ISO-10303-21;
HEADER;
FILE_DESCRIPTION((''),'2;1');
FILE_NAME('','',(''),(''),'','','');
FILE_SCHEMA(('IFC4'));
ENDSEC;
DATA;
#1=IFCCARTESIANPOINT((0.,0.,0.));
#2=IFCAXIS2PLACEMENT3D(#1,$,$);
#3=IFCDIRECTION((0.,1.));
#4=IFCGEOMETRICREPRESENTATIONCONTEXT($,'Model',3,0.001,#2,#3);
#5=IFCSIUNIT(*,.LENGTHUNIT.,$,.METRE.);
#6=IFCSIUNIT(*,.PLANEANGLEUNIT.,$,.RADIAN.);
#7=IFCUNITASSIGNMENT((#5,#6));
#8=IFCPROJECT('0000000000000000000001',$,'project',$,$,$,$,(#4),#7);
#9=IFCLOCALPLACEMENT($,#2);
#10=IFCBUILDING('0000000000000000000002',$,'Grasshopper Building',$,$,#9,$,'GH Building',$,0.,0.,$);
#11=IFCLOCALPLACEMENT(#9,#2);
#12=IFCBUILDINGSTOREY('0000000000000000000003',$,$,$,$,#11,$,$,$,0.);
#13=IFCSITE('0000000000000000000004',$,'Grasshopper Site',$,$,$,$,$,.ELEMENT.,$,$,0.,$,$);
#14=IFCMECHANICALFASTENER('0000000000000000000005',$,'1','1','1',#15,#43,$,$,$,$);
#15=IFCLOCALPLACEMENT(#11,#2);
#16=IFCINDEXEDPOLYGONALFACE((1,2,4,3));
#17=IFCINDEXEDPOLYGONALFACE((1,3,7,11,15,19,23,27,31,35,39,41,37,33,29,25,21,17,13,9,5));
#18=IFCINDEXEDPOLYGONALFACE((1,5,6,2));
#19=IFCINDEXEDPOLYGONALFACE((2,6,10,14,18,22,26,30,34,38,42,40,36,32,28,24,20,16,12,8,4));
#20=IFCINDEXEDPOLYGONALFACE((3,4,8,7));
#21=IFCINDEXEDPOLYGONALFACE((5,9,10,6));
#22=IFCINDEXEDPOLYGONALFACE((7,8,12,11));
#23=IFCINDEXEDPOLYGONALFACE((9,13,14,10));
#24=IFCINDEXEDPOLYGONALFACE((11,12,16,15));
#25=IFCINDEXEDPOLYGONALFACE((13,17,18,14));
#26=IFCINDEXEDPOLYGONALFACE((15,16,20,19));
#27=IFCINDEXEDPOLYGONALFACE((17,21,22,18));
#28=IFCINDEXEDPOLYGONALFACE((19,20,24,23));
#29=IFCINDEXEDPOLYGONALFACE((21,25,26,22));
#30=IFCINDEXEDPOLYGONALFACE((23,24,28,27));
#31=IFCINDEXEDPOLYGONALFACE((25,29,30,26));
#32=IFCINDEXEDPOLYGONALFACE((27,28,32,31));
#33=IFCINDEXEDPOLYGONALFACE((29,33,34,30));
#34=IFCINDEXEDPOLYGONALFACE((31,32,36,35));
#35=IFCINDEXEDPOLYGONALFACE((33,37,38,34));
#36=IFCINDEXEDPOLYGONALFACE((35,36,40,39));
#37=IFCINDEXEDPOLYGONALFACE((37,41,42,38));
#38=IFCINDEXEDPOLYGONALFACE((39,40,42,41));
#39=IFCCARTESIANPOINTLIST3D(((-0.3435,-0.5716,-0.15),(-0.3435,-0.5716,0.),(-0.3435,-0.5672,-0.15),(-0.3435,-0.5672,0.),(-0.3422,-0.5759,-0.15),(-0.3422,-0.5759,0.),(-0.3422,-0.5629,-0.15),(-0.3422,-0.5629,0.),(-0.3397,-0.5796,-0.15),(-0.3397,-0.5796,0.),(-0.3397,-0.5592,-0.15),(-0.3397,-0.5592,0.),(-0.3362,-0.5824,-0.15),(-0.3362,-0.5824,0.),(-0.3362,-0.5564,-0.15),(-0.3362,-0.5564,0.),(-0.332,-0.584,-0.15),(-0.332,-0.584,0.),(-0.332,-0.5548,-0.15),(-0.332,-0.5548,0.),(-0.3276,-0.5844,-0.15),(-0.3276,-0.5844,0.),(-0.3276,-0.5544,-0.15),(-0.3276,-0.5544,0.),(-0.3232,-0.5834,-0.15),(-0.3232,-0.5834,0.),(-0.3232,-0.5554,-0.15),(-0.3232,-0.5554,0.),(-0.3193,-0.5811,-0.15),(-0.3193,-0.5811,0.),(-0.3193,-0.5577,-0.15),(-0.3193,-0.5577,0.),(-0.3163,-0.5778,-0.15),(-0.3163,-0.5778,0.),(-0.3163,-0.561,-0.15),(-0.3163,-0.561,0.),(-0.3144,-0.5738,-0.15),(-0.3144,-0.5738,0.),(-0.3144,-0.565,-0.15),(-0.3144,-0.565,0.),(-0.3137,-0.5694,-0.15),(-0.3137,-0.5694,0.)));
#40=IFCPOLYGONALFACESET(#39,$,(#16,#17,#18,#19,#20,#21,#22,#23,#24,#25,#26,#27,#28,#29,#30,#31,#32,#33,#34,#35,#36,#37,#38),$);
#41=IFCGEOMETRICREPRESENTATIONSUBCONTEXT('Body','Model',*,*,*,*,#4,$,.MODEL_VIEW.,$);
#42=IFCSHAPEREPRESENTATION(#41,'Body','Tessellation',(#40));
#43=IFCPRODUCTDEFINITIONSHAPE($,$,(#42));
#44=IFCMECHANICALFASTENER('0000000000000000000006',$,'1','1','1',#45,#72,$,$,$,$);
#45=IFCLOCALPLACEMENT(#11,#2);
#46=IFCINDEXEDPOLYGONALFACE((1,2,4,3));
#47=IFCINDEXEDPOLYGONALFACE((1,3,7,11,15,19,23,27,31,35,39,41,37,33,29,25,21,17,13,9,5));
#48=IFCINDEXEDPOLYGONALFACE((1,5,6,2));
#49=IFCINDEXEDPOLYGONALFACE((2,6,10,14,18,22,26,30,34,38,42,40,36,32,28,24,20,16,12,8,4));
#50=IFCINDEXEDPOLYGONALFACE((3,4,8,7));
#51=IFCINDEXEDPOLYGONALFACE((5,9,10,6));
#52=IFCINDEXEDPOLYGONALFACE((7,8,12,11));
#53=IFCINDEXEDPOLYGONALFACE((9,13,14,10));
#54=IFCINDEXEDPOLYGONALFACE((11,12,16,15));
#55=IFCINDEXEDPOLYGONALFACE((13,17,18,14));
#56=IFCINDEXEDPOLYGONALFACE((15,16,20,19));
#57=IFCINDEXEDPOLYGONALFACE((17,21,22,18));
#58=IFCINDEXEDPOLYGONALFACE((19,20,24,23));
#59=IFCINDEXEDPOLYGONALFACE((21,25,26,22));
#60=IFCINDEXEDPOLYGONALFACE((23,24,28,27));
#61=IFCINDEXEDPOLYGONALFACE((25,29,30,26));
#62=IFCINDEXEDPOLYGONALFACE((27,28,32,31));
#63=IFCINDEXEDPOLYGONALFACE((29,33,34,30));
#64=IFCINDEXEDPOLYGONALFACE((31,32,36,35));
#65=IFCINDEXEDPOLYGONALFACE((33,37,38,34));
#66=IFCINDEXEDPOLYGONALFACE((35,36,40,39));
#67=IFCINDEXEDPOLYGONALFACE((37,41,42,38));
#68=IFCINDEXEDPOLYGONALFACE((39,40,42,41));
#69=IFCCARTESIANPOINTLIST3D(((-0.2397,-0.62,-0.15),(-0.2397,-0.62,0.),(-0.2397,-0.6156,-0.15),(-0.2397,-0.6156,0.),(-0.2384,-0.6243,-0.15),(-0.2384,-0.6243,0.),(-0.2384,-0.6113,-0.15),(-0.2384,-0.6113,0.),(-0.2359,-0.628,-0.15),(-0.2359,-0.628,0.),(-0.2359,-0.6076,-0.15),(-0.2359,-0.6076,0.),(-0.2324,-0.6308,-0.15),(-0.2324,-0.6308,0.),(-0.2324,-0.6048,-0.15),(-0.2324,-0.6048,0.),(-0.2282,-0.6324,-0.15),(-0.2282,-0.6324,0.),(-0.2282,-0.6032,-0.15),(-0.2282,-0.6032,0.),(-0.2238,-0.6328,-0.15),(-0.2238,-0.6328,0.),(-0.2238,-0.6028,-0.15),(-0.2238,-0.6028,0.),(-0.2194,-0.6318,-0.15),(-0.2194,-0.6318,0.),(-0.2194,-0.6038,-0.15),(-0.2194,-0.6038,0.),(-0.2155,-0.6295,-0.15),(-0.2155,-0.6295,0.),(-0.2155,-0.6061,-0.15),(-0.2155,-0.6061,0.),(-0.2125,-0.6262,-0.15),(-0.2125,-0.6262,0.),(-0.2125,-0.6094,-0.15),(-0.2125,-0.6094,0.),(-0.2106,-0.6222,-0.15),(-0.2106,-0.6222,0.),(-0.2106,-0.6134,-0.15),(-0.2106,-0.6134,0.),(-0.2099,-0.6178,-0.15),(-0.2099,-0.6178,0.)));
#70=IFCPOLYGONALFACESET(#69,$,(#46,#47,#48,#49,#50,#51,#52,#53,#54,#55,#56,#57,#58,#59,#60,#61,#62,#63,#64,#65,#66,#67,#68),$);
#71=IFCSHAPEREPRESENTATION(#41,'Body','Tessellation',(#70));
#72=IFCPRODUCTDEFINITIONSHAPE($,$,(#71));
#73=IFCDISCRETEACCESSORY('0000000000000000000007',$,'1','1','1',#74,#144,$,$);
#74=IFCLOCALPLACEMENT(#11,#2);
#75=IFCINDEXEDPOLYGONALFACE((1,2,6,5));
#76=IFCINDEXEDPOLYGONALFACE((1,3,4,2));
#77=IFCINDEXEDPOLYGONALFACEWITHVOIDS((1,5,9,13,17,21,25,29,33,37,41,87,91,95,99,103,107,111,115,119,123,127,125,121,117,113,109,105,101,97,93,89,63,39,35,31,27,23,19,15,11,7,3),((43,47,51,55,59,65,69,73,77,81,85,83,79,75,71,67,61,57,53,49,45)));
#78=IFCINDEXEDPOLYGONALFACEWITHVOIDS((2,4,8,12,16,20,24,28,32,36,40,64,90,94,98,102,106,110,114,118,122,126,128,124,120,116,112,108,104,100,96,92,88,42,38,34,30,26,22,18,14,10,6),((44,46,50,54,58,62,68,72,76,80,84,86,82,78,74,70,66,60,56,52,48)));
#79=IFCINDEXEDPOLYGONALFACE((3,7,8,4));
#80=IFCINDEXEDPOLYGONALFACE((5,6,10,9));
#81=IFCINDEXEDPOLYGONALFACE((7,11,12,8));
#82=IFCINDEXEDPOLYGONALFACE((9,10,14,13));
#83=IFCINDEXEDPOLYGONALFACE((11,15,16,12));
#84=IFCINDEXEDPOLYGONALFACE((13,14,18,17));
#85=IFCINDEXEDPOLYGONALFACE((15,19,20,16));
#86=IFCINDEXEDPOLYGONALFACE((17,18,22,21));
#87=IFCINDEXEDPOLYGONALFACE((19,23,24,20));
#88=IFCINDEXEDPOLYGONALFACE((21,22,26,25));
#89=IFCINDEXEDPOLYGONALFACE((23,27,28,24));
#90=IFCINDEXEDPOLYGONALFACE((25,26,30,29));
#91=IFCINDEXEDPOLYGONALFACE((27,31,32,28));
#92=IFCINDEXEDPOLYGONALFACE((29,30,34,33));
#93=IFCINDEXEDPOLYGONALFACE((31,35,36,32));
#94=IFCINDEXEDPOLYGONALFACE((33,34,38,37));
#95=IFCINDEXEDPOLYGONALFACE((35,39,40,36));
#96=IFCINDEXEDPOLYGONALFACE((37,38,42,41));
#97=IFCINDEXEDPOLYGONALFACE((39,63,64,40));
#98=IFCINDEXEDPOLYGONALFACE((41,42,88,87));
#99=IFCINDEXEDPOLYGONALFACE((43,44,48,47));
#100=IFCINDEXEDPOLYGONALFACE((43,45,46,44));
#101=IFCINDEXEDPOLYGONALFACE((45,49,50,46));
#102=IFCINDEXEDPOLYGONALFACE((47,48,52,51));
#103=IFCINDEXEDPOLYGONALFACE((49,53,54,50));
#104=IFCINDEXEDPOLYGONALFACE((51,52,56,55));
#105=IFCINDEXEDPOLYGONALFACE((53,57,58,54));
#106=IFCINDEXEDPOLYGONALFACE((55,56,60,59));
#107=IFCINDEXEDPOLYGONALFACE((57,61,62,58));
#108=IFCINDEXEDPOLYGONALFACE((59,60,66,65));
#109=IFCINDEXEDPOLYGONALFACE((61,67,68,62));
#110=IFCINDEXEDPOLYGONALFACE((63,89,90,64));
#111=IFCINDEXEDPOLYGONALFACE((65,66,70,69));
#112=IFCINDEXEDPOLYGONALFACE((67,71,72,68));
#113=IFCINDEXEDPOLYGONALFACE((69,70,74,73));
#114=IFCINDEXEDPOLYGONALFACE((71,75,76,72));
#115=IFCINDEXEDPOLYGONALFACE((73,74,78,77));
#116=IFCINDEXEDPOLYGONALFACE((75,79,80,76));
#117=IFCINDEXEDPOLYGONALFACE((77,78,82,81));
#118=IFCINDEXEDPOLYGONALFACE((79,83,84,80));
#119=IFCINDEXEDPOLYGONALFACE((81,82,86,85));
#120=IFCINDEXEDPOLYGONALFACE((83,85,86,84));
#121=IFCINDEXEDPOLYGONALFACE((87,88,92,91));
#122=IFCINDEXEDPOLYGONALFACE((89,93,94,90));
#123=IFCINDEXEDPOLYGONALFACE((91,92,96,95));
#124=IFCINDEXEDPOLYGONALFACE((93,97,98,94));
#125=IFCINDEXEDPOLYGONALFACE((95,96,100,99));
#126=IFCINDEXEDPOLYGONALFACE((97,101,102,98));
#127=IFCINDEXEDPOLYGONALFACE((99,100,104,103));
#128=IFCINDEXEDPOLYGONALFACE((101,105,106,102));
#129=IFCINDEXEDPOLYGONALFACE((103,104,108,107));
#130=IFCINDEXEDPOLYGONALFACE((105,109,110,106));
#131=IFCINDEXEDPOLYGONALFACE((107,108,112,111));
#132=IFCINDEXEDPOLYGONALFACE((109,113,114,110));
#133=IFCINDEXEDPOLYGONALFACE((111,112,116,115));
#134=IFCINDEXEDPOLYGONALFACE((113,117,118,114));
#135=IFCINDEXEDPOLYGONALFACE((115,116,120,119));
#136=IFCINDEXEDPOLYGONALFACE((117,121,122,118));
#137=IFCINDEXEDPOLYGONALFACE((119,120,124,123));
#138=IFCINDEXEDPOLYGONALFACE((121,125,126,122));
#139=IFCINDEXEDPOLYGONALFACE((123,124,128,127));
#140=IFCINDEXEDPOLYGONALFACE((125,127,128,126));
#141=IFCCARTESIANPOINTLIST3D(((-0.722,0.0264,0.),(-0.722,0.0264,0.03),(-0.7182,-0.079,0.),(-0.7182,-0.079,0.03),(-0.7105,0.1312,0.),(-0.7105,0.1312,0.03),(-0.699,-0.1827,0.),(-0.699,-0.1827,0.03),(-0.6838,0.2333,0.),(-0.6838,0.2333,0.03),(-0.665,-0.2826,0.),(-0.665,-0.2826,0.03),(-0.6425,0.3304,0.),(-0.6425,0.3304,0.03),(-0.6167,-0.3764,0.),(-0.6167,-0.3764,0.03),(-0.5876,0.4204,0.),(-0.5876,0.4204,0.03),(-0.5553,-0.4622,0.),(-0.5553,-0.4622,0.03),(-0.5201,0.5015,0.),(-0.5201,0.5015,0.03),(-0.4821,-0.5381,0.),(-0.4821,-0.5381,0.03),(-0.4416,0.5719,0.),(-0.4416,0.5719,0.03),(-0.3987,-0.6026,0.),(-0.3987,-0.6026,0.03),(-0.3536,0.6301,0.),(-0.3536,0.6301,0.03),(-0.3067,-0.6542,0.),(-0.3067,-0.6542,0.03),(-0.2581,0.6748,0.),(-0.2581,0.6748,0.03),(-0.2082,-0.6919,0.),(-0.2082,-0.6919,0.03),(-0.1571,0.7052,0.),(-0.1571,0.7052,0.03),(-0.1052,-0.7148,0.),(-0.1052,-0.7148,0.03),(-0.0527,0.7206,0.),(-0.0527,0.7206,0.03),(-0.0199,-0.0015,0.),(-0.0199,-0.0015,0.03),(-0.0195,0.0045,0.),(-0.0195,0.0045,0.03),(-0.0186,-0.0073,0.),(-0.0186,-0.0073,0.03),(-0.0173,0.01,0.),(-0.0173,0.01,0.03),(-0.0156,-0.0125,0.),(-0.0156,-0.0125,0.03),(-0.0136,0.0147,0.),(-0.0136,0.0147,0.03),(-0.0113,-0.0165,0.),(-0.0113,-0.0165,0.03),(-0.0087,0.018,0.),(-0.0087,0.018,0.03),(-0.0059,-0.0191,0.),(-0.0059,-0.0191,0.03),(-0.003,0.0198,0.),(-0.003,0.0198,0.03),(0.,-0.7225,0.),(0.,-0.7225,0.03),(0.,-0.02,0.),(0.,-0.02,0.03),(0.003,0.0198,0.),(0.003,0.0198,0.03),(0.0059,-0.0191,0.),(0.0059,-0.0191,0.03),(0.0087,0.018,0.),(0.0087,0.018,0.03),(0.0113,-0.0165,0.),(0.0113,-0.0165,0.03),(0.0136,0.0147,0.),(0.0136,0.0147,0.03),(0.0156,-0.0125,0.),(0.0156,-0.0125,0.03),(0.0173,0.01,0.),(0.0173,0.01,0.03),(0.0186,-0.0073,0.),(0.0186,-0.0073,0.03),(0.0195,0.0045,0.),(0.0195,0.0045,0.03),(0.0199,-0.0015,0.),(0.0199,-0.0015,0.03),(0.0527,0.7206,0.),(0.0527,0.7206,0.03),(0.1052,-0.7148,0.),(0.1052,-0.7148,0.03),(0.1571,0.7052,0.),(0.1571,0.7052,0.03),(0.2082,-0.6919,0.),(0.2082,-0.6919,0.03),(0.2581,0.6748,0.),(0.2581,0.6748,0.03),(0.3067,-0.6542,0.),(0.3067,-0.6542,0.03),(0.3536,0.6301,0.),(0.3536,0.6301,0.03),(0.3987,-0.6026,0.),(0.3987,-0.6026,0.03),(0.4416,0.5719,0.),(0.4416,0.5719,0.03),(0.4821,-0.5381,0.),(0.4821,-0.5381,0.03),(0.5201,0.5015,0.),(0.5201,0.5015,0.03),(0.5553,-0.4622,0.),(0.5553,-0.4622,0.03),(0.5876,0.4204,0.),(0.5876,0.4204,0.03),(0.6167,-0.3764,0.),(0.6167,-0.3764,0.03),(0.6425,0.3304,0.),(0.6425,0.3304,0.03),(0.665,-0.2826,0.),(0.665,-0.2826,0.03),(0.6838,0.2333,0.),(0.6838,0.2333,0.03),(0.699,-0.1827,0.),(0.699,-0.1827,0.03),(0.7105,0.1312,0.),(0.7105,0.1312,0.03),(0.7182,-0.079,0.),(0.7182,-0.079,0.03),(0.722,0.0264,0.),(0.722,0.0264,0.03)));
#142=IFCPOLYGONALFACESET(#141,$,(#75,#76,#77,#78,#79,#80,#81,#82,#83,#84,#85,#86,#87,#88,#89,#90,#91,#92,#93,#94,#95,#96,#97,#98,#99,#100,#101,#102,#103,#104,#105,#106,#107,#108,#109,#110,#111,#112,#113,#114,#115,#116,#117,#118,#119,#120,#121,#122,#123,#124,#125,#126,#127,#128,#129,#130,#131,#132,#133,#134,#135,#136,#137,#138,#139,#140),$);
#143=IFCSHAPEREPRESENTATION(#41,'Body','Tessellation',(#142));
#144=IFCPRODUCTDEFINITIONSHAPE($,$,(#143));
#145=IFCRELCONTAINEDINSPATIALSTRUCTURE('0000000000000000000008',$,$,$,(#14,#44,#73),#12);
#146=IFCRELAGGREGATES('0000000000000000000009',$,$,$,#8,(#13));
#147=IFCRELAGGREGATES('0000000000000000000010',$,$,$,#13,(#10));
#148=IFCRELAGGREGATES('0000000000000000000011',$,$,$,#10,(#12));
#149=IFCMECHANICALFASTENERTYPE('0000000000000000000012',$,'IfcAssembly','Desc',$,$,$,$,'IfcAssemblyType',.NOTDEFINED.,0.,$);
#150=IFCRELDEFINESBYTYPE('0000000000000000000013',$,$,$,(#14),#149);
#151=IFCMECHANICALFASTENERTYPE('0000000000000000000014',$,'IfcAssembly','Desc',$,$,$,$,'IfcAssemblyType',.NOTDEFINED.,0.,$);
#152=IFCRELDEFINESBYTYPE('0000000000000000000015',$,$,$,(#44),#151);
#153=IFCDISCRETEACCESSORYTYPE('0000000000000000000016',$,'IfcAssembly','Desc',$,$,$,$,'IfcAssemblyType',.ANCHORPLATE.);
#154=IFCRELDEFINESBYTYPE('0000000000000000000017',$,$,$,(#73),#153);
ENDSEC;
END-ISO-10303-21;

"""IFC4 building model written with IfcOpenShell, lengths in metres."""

from ifc_helpers import new_model, si_unit, direction, frame, origin, place, context, subcontext, project, spatial, circle, hollow_circle, extrude, source, transform, mapped, type_object, type_shapes, element, save


model = new_model("IFC4")

# Units and contexts
model_context = context("Model", 3, precision=0.001, world=origin(), true_north=direction((0.0, 1.0)))
body_context = subcontext(model_context, "Body", "Model", "MODEL_VIEW")
ifc_project = project(units=[si_unit("LENGTHUNIT", "METRE"), si_unit("PLANEANGLEUNIT", "RADIAN")], contexts=[model_context])

# Site, building, storey
site = spatial("IfcSite", under=ifc_project, Name="Grasshopper Site", CompositionType="ELEMENT", RefElevation=0.0)
building_placement = place(None, origin())
building = spatial("IfcBuilding", under=site, at=building_placement, Name="Grasshopper Building", LongName="GH Building", ElevationOfRefHeight=0.0, ElevationOfTerrain=0.0)
storey_placement = place(building_placement, origin())
storey = spatial("IfcBuildingStorey", under=building, at=storey_placement, Elevation=0.0)

# Mechanical fasteners
mechanical_fastener_type_1 = type_object("IfcMechanicalFastenerType", Name="IfcAssembly", Description="Desc", ElementType="IfcAssemblyType", NominalDiameter=0.0)
shared_shape_1 = source(origin(), body_context, "Body", "SweptSolid", [
    extrude(circle(Radius=0.015), frame((-0.3287, -0.5694, 0.0), z_axis=(0.0, 0.0, -1.0), x_axis=(1.0, 0.0, 0.0)), (0.0, 0.0, 1.0), 0.15),
])
type_shapes(mechanical_fastener_type_1, [shared_shape_1])
mechanical_fastener_1_placement = place(storey_placement, origin())
element("IfcMechanicalFastener", 1, at=mechanical_fastener_1_placement, inside=storey, type_object=mechanical_fastener_type_1, Name="1", Description="1", ObjectType="1", context=body_context, shape_type="MappedRepresentation", body=[
    mapped(shared_shape_1, transform((0.0, 0.0, 0.0), scale=1.0)),
])
mechanical_fastener_type_2 = type_object("IfcMechanicalFastenerType", Name="IfcAssembly", Description="Desc", ElementType="IfcAssemblyType", NominalDiameter=0.0)
shared_shape_2 = source(origin(), body_context, "Body", "SweptSolid", [
    extrude(circle(Radius=0.015), frame((-0.2249, -0.6178, 0.0), z_axis=(0.0, 0.0, -1.0), x_axis=(1.0, 0.0, 0.0)), (0.0, 0.0, 1.0), 0.15),
])
type_shapes(mechanical_fastener_type_2, [shared_shape_2])
mechanical_fastener_2_placement = place(storey_placement, origin())
element("IfcMechanicalFastener", 2, at=mechanical_fastener_2_placement, inside=storey, type_object=mechanical_fastener_type_2, Name="1", Description="1", ObjectType="1", context=body_context, shape_type="MappedRepresentation", body=[
    mapped(shared_shape_2, transform((0.0, 0.0, 0.0), scale=1.0)),
])

# Discrete accessory
discrete_accessory_type = type_object("IfcDiscreteAccessoryType", Name="IfcAssembly", Description="Desc", ElementType="IfcAssemblyType", PredefinedType="ANCHORPLATE")
shared_shape_3 = source(origin(), body_context, "Body", "SweptSolid", [
    extrude(hollow_circle(Radius=0.7225, WallThickness=0.7025), frame((0.0, 0.0, 0.0), z_axis=(0.0, 0.0, 1.0), x_axis=(0.0, -1.0, 0.0)), (0.0, 0.0, 1.0), 0.03),
])
type_shapes(discrete_accessory_type, [shared_shape_3])
discrete_accessory_placement = place(storey_placement, origin())
element("IfcDiscreteAccessory", 3, at=discrete_accessory_placement, inside=storey, type_object=discrete_accessory_type, Name="1", Description="1", ObjectType="1", context=body_context, shape_type="MappedRepresentation", body=[
    mapped(shared_shape_3, transform((0.0, 0.0, 0.0), scale=1.0)),
])

save(model, "model.ifc")
